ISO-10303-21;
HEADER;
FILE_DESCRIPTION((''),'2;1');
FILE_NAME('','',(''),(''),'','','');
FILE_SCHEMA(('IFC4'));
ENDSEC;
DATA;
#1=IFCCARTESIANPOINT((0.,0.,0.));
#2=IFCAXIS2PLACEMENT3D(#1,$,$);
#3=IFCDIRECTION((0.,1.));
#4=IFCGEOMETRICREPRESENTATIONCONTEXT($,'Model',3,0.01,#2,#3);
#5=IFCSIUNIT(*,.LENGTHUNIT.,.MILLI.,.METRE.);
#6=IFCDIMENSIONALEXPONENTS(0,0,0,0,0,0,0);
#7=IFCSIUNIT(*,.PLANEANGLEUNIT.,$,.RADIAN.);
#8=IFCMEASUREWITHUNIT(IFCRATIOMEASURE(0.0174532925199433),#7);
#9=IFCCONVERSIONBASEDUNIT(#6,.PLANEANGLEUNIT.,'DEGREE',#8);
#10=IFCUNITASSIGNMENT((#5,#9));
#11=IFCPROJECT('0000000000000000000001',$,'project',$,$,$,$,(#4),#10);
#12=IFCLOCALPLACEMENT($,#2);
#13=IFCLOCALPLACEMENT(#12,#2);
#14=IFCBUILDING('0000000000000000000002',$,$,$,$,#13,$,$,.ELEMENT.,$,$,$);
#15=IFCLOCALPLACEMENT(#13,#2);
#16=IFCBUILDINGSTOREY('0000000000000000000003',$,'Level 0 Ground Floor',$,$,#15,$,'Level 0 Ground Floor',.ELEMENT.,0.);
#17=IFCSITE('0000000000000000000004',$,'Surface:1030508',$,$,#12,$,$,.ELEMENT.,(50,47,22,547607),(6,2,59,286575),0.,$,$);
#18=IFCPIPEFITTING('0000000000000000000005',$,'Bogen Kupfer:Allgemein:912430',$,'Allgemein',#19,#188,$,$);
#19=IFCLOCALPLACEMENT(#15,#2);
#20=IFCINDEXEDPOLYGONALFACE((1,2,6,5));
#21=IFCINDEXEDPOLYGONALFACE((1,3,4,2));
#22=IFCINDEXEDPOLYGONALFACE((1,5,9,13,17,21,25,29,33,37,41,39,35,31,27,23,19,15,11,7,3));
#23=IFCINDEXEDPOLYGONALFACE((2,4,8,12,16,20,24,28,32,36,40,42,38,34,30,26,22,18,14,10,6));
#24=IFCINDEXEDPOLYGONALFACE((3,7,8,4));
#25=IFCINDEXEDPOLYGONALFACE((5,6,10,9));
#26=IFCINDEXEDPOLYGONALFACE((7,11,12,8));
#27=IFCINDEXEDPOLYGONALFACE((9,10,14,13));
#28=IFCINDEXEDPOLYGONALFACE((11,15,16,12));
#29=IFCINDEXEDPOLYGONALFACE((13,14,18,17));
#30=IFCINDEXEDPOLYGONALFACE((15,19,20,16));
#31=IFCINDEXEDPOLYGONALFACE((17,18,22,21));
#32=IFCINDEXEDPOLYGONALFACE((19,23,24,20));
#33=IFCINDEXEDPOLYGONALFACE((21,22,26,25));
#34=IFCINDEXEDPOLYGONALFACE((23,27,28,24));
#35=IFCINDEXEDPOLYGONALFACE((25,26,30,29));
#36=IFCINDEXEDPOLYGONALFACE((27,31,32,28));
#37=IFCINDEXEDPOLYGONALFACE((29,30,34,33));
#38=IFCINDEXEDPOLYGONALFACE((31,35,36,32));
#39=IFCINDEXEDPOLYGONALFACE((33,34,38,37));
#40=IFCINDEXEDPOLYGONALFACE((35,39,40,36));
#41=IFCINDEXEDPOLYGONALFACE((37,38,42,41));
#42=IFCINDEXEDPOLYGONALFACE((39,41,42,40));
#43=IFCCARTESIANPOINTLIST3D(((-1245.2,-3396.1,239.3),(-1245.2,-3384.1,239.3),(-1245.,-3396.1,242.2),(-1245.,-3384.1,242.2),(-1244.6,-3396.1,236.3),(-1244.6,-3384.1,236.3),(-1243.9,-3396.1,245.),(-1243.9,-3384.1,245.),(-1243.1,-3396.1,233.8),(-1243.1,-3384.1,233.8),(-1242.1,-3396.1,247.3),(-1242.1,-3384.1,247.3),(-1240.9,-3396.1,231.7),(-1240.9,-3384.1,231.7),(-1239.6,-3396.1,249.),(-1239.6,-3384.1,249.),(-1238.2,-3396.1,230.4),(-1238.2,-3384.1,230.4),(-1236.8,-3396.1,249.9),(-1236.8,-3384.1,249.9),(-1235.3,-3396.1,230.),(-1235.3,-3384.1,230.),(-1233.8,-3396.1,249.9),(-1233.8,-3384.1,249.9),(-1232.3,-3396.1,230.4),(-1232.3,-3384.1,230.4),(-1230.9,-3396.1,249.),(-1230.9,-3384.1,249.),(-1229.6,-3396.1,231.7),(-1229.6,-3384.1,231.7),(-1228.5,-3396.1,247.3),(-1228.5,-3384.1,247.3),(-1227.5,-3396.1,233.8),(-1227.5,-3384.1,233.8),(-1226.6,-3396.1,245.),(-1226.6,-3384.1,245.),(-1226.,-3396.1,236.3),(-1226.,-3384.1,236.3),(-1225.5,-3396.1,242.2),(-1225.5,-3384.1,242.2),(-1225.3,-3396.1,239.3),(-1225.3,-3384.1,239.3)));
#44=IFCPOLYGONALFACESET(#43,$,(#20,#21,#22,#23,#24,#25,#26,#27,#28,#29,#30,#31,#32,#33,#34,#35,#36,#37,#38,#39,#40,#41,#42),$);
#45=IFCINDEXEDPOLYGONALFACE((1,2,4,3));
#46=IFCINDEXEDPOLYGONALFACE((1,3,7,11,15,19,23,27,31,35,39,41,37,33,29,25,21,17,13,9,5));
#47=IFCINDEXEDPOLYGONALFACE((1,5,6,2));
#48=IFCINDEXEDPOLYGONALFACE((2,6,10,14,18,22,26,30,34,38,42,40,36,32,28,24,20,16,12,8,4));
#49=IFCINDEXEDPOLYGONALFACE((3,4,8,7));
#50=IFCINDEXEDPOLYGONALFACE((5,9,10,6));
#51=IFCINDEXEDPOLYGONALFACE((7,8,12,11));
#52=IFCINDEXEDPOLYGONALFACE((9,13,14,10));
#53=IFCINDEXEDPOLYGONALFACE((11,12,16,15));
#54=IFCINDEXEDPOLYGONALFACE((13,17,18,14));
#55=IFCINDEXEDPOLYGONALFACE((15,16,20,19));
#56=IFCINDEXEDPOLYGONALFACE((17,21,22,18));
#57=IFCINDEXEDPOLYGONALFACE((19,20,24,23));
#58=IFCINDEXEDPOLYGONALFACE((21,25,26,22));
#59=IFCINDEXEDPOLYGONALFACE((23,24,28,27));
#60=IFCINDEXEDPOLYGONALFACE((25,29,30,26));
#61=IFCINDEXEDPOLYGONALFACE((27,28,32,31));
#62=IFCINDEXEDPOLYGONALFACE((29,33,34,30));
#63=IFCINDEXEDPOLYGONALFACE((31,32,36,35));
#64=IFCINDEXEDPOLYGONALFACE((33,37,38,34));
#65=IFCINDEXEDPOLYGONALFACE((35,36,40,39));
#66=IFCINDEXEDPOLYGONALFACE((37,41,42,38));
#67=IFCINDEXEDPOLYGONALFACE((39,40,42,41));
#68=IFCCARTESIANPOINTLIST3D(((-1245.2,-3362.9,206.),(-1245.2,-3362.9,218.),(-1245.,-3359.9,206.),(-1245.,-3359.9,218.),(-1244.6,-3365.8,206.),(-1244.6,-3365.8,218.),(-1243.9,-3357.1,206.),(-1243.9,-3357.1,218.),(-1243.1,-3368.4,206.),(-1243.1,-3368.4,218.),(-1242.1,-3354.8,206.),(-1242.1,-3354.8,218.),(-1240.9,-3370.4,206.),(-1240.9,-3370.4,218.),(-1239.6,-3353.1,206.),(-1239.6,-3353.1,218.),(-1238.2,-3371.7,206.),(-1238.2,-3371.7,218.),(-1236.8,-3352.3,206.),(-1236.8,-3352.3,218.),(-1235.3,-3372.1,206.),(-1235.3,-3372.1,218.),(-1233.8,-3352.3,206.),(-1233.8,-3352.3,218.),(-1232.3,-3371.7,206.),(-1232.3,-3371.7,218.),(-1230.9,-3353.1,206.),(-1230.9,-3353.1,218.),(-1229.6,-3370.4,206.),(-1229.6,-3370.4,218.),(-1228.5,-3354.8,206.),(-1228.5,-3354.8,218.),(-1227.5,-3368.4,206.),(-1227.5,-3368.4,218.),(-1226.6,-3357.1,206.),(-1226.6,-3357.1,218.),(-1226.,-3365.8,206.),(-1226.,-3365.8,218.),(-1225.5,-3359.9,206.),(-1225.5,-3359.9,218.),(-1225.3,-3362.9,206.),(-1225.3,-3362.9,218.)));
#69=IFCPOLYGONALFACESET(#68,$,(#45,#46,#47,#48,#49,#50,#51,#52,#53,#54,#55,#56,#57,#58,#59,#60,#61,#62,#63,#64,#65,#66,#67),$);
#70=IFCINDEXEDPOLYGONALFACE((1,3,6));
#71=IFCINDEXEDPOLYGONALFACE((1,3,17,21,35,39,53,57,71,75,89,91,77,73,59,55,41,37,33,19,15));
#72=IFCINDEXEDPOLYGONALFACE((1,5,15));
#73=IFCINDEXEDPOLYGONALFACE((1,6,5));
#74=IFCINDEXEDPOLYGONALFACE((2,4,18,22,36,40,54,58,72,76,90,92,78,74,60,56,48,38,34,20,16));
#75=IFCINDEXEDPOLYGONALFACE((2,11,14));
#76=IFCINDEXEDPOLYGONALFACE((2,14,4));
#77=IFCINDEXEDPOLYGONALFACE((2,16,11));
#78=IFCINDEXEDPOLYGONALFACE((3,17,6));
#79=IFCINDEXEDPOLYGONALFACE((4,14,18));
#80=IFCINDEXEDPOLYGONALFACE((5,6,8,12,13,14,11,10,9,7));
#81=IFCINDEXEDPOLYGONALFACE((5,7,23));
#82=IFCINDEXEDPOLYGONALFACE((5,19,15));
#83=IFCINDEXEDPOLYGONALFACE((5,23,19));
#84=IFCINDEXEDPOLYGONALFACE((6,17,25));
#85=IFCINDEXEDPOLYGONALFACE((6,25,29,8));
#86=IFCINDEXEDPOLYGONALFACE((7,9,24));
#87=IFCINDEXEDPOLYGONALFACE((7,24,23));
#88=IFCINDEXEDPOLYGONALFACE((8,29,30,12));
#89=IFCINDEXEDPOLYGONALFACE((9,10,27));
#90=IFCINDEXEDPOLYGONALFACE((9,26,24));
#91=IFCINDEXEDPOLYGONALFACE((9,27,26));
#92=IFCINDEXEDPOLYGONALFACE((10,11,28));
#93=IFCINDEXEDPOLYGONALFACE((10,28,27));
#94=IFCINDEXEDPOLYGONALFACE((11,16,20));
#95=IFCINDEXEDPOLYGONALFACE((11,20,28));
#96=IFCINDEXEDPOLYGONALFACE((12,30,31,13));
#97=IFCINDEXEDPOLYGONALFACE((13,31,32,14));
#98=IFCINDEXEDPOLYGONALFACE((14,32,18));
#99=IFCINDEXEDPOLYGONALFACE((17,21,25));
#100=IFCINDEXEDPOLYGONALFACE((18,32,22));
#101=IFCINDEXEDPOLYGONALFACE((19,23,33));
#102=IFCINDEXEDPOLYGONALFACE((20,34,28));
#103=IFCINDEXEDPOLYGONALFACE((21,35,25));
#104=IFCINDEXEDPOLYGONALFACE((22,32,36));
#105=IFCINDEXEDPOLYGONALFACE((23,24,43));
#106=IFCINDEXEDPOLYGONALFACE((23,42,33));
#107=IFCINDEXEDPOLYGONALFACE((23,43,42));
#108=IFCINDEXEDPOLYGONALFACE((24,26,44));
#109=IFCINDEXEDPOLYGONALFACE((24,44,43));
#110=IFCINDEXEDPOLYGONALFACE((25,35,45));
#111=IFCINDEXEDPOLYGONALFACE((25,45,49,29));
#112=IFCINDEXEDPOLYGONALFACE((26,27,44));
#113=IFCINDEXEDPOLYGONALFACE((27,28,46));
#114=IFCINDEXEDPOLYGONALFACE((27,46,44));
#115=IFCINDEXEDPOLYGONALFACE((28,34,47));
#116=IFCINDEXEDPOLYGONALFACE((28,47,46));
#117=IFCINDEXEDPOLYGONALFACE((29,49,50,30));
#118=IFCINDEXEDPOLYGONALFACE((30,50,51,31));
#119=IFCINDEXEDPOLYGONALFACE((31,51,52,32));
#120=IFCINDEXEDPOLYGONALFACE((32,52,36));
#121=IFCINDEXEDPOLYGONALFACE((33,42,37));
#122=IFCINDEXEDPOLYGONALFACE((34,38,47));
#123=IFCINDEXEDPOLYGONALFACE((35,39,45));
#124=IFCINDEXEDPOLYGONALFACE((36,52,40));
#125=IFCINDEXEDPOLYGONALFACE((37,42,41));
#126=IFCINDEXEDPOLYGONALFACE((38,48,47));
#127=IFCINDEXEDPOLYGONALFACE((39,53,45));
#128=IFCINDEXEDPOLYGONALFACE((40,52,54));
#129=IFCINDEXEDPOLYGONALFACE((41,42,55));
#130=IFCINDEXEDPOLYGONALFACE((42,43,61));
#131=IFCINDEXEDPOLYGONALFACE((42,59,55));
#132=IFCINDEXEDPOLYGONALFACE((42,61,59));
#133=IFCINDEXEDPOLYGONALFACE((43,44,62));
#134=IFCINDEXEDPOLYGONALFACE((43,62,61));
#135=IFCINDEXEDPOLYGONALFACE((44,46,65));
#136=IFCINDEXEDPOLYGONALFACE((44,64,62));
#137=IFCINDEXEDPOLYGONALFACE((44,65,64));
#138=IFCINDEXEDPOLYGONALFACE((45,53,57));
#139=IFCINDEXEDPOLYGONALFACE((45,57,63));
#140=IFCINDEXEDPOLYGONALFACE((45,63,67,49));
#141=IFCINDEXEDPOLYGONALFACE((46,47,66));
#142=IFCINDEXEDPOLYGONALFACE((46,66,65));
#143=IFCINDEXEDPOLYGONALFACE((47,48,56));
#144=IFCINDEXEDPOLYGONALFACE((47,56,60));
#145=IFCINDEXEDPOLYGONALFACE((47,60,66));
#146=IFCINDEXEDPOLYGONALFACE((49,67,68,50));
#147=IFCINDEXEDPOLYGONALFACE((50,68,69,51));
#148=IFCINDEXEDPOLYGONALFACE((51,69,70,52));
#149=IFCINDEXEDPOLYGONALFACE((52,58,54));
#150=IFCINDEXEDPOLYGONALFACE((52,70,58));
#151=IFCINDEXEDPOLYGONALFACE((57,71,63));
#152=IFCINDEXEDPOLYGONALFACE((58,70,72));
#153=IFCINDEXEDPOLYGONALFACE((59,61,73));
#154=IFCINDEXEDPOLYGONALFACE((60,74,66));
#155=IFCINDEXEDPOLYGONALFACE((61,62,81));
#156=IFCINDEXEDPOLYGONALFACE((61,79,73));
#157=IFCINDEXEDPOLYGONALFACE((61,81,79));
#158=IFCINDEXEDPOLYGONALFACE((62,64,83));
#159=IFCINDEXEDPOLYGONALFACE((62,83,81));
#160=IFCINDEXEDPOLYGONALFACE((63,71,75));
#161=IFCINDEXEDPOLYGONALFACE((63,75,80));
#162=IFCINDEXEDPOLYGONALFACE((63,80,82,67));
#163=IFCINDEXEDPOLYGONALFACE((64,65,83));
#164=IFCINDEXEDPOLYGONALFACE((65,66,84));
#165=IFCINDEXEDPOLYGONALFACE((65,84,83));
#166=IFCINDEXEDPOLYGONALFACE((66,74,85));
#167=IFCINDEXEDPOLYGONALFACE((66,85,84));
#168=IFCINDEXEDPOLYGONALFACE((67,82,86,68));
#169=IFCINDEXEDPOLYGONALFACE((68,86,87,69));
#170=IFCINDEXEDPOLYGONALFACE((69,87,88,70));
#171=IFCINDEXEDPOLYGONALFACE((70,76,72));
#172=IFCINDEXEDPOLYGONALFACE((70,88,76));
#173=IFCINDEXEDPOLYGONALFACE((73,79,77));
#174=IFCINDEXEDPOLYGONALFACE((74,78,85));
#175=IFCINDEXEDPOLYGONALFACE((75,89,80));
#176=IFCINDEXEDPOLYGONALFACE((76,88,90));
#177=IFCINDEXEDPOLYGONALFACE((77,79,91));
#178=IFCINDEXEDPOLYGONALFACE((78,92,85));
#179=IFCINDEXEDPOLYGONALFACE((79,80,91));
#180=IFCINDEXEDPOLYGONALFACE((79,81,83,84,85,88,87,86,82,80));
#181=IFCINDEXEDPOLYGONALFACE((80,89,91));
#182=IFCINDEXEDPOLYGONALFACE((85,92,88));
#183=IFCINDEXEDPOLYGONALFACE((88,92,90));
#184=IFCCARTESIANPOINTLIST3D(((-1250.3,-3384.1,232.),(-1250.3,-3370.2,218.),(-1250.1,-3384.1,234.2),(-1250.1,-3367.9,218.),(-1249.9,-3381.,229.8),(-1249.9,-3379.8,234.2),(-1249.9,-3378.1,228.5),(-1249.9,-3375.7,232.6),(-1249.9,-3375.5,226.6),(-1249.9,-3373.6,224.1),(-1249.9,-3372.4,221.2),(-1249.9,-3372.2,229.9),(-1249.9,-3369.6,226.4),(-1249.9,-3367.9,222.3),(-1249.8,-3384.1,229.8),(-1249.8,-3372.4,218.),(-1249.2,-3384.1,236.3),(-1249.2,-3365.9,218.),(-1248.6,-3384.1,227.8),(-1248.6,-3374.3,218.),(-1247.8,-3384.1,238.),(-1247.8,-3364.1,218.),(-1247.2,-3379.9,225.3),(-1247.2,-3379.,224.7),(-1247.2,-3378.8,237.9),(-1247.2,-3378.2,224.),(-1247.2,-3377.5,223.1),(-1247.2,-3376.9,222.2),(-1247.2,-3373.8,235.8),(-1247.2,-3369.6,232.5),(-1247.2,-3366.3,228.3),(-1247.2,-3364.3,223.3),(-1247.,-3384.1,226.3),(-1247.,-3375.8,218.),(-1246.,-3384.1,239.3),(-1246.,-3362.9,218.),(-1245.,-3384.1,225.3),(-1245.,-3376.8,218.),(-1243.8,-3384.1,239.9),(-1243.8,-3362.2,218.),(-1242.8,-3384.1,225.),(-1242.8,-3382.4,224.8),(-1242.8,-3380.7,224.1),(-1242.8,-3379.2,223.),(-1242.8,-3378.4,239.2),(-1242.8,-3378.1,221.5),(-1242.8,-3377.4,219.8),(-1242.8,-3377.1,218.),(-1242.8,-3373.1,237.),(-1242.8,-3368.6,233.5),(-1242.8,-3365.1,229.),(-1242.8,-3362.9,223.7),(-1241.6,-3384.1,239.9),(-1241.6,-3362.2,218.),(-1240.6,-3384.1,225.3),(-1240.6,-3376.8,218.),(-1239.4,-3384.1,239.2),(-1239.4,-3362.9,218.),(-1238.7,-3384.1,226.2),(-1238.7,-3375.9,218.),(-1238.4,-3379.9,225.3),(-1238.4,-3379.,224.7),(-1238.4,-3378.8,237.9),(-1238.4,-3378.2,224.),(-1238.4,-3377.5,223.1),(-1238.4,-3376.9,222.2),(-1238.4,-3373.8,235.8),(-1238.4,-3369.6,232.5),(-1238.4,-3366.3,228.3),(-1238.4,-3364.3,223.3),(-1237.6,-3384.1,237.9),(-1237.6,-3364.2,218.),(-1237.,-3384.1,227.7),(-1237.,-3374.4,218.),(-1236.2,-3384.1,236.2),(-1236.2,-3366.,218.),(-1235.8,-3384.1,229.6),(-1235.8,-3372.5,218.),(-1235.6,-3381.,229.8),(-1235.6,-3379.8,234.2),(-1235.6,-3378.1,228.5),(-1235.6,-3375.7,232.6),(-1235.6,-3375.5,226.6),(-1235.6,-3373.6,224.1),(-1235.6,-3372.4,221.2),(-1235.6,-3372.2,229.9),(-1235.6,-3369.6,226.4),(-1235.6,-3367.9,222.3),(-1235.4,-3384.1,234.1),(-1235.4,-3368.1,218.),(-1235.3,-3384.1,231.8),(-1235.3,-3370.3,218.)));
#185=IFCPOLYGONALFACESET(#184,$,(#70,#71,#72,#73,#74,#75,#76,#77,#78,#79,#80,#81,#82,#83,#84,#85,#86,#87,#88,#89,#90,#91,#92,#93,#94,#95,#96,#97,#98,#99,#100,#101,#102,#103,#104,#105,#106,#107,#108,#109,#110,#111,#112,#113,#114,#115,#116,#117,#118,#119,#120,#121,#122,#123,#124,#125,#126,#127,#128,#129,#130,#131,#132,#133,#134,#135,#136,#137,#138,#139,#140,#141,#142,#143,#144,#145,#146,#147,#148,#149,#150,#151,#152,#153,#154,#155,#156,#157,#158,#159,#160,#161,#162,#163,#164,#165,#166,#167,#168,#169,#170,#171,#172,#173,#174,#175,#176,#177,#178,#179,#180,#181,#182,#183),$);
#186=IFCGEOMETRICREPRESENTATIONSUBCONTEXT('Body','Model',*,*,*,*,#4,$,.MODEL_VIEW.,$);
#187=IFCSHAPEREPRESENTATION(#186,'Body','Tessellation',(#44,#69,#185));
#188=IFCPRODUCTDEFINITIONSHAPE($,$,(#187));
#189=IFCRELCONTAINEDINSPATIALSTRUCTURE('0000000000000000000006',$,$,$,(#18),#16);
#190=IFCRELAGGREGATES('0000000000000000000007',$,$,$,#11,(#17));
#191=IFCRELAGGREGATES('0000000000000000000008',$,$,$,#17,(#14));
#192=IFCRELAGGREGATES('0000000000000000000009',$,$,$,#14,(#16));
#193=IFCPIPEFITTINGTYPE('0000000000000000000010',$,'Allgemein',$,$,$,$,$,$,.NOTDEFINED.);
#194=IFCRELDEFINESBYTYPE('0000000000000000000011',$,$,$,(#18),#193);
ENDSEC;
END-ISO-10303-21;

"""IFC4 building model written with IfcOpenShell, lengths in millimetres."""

from ifc_helpers import new_model, entity, si_unit, converted_unit, direction, frame, frame_2d, origin, place, context, subcontext, project, spatial, circle, extrude, source, transform, mapped, type_object, type_shapes, element, save


model = new_model("IFC4")

# Units and contexts
model_context = context("Model", 3, precision=0.01, world=origin(), true_north=direction((0.0, 1.0)))
body_context = subcontext(model_context, "Body", "Model", "MODEL_VIEW")
ifc_project = project(units=[si_unit("LENGTHUNIT", "METRE", prefix="MILLI"), converted_unit("PLANEANGLEUNIT", "DEGREE", entity("IfcRatioMeasure", 0.0174532925199433), si_unit("PLANEANGLEUNIT", "RADIAN"), dimensions=[0, 0, 0, 0, 0, 0, 0])], contexts=[model_context])

# Site, building, storey
site_placement = place(None, origin())
site = spatial("IfcSite", under=ifc_project, at=site_placement, Name="Surface:1030508", CompositionType="ELEMENT", RefLatitude=(50, 47, 22, 547607), RefLongitude=(6, 2, 59, 286575), RefElevation=0.0)
building_placement = place(site_placement, origin())
building = spatial("IfcBuilding", under=site, at=building_placement, CompositionType="ELEMENT")
storey_placement = place(building_placement, origin())
storey = spatial("IfcBuildingStorey", under=building, at=storey_placement, Name="Level 0 Ground Floor", LongName="Level 0 Ground Floor", CompositionType="ELEMENT", Elevation=0.0)

# Pipe fitting
pipe_fitting_type_1 = type_object("IfcPipeFittingType", Name="Allgemein", PredefinedType="NOTDEFINED")
ifc_direction_1 = entity("IfcDirection", [0.0, 0.0, -1.0])
trimmed_curve_1 = entity("IfcTrimmedCurve", entity("IfcCircle", entity("IfcAxis2Placement2D", entity("IfcCartesianPoint", [-14.5, 0.0]), entity("IfcDirection", [0.0, 1.0])), 14.5), [entity("IfcParameterValue", 270.0)], [entity("IfcParameterValue", 0.0)], True, "PARAMETER")
shared_shape_1 = source(origin(), body_context, "Body", "SolidModel", [
    extrude(circle(Radius=10.0, at=frame_2d((0.0, 0.0), x_axis=(1.0, 0.0))), frame((0.0, 22.0, 0.0), z_axis=(0.0, 1.0, 0.0), x_axis=(-1.0, 0.0, 0.0)), (0.0, 0.0, 1.0), 12.0),
    extrude(circle(Radius=10.0, at=frame_2d((0.0, 0.0), x_axis=(1.0, 0.0))), frame((-34.0, 0.0, 0.0), z_axis=(1.0, 0.0, 0.0), x_axis=(0.0, 1.0, 0.0)), (0.0, 0.0, 1.0), 12.0),
    entity("IfcSurfaceCurveSweptAreaSolid", entity("IfcCircleProfileDef", "AREA", None, entity("IfcAxis2Placement2D", entity("IfcCartesianPoint", [0.0, 7.5]), entity("IfcDirection", [1.0, 0.0])), 7.5), entity("IfcAxis2Placement3D", entity("IfcCartesianPoint", [-7.5, 22.0, 0.0]), ifc_direction_1, entity("IfcDirection", [1.0, 0.0, 0.0])), trimmed_curve_1, 0.0, 90.0, entity("IfcSurfaceOfLinearExtrusion", entity("IfcArbitraryOpenProfileDef", "CURVE", None, trimmed_curve_1), entity("IfcAxis2Placement3D", entity("IfcCartesianPoint", [0.0, 0.0, -304.8])), ifc_direction_1, 1.0)),
])
type_shapes(pipe_fitting_type_1, [shared_shape_1])
for number, where, z_axis, x_axis, name in (
    (1, (-1235.3, -3362.1, 240.0), (1.0, 0.0, 0.0), (0.0, 0.0, 1.0), "Bogen Kupfer:Allgemein:912430"),
):
    element("IfcPipeFitting", number, at=place(storey_placement, frame(where, z_axis=z_axis, x_axis=x_axis)), inside=storey, type_object=pipe_fitting_type_1, Name=name, ObjectType="Allgemein", context=body_context, shape_type="MappedRepresentation", body=[
        mapped(shared_shape_1, transform((0.0, 0.0, 0.0), scale=1.0)),
    ])

save(model, "model.ifc")
